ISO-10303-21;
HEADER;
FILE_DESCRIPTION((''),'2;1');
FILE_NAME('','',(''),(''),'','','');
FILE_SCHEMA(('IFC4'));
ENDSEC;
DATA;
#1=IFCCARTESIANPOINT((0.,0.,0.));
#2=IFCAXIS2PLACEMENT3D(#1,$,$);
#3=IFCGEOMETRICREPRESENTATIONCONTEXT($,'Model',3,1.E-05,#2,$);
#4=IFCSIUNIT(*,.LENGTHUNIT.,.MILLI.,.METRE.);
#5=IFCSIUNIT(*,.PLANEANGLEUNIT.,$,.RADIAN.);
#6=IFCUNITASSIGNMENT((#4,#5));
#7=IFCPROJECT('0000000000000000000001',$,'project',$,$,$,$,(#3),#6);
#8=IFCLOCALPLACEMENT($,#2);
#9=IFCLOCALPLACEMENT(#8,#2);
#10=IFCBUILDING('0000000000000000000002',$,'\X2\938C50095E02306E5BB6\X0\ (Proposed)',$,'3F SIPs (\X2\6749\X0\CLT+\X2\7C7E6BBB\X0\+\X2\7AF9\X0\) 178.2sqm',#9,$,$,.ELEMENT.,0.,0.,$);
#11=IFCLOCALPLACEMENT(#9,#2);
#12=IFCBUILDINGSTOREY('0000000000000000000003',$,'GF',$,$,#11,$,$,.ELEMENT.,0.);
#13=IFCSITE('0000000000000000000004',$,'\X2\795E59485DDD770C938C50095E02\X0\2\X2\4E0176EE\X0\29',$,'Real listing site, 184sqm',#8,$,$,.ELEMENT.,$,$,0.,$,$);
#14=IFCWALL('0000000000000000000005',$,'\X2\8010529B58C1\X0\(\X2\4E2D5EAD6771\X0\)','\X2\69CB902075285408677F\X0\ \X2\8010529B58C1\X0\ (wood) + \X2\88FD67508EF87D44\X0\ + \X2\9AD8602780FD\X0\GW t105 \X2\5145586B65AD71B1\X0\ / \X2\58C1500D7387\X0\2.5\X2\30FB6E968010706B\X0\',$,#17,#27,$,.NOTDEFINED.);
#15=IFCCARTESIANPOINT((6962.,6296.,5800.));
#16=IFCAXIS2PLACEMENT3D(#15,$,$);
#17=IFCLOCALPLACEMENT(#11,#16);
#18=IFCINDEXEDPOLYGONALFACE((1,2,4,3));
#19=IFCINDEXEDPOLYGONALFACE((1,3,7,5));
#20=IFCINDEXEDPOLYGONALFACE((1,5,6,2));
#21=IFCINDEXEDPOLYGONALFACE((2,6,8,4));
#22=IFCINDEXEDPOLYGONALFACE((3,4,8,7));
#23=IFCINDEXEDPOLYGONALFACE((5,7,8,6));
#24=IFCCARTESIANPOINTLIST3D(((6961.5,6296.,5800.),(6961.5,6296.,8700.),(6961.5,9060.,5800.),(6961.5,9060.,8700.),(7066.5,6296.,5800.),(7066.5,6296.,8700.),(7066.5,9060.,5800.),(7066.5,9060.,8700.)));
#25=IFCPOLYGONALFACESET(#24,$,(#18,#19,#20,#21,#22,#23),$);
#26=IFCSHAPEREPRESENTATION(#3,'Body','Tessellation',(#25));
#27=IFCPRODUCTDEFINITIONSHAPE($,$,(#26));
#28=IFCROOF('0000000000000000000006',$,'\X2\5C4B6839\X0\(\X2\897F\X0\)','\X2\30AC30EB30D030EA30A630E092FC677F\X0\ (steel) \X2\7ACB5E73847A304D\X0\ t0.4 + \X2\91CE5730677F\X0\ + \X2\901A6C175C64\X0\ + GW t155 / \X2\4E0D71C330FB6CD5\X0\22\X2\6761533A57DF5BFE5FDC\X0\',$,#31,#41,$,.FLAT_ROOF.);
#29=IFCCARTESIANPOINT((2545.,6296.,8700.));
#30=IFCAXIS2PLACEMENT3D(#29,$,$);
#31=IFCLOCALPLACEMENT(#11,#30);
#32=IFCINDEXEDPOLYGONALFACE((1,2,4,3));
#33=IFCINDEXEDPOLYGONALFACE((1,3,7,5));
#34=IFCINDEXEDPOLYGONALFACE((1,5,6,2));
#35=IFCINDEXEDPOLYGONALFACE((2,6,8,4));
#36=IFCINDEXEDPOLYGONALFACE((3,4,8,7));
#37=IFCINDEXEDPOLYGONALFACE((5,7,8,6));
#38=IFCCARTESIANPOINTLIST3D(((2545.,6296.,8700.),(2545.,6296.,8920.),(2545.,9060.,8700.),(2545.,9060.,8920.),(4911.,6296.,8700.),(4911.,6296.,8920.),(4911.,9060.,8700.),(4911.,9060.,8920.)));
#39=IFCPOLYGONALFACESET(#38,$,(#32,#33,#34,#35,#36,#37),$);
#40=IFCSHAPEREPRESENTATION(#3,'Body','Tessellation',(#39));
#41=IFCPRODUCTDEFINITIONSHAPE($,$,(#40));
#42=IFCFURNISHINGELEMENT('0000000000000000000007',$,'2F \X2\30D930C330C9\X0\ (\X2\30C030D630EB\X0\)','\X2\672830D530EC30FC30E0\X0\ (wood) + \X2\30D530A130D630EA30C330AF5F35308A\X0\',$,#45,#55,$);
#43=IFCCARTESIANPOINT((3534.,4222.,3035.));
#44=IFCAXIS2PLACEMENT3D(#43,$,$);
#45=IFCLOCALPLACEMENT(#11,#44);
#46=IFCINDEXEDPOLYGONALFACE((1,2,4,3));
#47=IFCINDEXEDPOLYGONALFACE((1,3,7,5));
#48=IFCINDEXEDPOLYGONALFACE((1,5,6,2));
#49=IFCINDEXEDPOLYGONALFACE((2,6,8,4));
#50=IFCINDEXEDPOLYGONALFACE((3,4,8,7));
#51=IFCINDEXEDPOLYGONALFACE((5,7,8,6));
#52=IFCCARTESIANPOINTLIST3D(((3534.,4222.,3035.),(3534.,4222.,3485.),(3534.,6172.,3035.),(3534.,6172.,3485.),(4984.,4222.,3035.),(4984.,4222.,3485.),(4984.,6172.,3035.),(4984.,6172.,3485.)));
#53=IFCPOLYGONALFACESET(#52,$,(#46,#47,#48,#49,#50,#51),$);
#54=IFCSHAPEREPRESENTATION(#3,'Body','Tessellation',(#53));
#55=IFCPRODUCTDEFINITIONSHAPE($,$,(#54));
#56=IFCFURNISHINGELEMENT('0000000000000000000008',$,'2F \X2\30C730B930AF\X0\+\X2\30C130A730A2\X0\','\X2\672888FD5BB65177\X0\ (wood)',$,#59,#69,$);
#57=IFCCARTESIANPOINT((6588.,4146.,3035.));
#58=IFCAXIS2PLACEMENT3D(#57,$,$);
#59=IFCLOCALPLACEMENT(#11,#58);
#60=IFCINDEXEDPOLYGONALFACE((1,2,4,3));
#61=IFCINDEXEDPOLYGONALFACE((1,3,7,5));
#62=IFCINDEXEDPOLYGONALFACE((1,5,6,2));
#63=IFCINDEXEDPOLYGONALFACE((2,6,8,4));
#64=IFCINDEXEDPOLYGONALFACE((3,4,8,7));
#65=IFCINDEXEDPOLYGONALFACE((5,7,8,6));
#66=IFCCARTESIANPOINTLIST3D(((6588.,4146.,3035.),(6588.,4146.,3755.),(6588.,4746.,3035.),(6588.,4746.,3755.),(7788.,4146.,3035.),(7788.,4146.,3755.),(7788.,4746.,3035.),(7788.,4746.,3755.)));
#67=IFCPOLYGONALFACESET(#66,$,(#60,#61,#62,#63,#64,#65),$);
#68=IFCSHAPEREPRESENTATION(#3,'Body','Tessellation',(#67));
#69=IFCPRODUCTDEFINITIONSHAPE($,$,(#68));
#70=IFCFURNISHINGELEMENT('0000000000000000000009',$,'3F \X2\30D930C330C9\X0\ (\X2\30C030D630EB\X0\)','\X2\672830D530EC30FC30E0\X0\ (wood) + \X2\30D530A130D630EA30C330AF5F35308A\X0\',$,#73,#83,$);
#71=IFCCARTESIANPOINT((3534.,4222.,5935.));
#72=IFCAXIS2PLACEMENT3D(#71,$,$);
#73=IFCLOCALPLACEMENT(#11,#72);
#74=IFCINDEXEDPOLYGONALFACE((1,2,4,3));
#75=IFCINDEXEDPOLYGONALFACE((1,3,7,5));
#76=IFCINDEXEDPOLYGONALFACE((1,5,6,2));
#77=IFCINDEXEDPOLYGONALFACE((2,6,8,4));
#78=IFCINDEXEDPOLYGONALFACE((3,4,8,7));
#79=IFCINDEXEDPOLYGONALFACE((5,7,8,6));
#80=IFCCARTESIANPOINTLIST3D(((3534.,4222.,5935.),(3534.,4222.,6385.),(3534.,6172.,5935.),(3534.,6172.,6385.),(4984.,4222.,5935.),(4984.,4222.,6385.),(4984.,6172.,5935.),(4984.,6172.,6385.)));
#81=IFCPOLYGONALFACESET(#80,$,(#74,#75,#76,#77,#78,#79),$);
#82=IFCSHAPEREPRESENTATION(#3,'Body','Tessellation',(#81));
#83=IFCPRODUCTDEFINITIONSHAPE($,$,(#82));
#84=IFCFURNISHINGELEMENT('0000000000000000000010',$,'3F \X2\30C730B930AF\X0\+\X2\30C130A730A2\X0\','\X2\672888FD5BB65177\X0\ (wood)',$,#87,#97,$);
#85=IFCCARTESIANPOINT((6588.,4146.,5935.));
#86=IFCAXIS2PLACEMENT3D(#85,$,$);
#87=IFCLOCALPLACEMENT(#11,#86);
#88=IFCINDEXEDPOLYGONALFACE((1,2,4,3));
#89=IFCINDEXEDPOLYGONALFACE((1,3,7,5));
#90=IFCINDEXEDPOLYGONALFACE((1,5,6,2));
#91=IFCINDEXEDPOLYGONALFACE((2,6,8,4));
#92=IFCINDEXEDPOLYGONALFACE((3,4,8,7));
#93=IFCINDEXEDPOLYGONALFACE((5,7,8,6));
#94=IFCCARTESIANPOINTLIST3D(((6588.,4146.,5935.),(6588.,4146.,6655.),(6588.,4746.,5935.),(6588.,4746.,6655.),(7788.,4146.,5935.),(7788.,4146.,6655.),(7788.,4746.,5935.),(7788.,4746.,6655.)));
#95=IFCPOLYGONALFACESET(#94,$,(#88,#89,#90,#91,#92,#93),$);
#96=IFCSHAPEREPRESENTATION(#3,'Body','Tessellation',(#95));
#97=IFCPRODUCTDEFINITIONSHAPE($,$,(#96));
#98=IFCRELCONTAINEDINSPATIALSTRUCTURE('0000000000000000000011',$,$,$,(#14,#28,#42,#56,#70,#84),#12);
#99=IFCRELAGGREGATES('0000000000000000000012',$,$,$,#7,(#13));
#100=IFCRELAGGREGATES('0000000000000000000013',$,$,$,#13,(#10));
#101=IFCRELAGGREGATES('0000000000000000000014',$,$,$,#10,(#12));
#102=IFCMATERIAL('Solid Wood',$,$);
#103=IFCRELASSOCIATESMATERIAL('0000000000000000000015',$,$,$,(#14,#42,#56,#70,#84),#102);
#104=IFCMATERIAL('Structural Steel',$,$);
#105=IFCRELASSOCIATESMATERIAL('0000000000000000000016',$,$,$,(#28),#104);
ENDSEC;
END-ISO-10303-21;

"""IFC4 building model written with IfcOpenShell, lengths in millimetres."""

from ifc_helpers import new_model, si_unit, frame, frame_2d, origin, place, context, project, spatial, rectangle, extrude, material, element, save


model = new_model("IFC4")

# Units and contexts
model_context = context("Model", 3, precision=1e-05, world=origin())
ifc_project = project(units=[si_unit("LENGTHUNIT", "METRE", prefix="MILLI"), si_unit("PLANEANGLEUNIT", "RADIAN")], contexts=[model_context])

# Site, building, storey
site_placement = place(None, origin())
site = spatial("IfcSite", under=ifc_project, at=site_placement, Name="神奈川県鎌倉市2丁目29", ObjectType="Real listing site, 184sqm", CompositionType="ELEMENT", RefElevation=0.0)
building_placement = place(site_placement, origin())
building = spatial("IfcBuilding", under=site, at=building_placement, Name="鎌倉市の家 (Proposed)", ObjectType="3F SIPs (杉CLT+籾殻+竹) 178.2sqm", CompositionType="ELEMENT", ElevationOfRefHeight=0.0, ElevationOfTerrain=0.0)
storey_placement = place(building_placement, origin())
storey = spatial("IfcBuildingStorey", under=building, at=storey_placement, Name="GF", CompositionType="ELEMENT", Elevation=0.0)

# Shared definitions
ifc_material_1 = material(Name="Solid Wood")

# Wall
wall_1_placement = place(storey_placement, frame((6962.0, 6296.0, 5800.0)))
element("IfcWall", 1, at=wall_1_placement, inside=storey, material=ifc_material_1, Name="耐力壁(中庭東)", Description="構造用合板 耐力壁 (wood) + 製材軸組 + 高性能GW t105 充填断熱 / 壁倍率2.5・準耐火", PredefinedType="NOTDEFINED", context=model_context, shape_type="SweptSolid", body=[
    extrude(rectangle(XDim=105.0, YDim=2764.0, at=frame_2d((52.0, 1382.0))), frame((6962.0, 6296.0, 5800.0)), (0.0, 0.0, 1.0), 2900.0),
])

# Roof
ifc_material_2 = material(Name="Structural Steel")
roof_1_placement = place(storey_placement, frame((2545.0, 6296.0, 8700.0)))
element("IfcRoof", 2, at=roof_1_placement, inside=storey, material=ifc_material_2, Name="屋根(西)", Description="ガルバリウム鋼板 (steel) 立平葺き t0.4 + 野地板 + 通気層 + GW t155 / 不燃・法22条区域対応", PredefinedType="FLAT_ROOF", context=model_context, shape_type="SweptSolid", body=[
    extrude(rectangle(XDim=2366.0, YDim=2764.0, at=frame_2d((1183.0, 1382.0))), frame((2545.0, 6296.0, 8700.0)), (0.0, 0.0, 1.0), 220.0),
])

# Furnishing elements
furnishing_1_placement = place(storey_placement, frame((3534.0, 4222.0, 3035.0)))
element("IfcFurnishingElement", 3, at=furnishing_1_placement, inside=storey, material=ifc_material_1, Name="2F ベッド (ダブル)", Description="木フレーム (wood) + ファブリック張り", context=model_context, shape_type="SweptSolid", body=[
    extrude(rectangle(XDim=1450.0, YDim=1950.0, at=frame_2d((725.0, 975.0))), frame((3534.0, 4222.0, 3035.0)), (0.0, 0.0, 1.0), 450.0),
])
furnishing_2_placement = place(storey_placement, frame((6588.0, 4146.0, 3035.0)))
element("IfcFurnishingElement", 4, at=furnishing_2_placement, inside=storey, material=ifc_material_1, Name="2F デスク+チェア", Description="木製家具 (wood)", context=model_context, shape_type="SweptSolid", body=[
    extrude(rectangle(XDim=1200.0, YDim=600.0, at=frame_2d((600.0, 300.0))), frame((6588.0, 4146.0, 3035.0)), (0.0, 0.0, 1.0), 720.0),
])
furnishing_3_placement = place(storey_placement, frame((3534.0, 4222.0, 5935.0)))
element("IfcFurnishingElement", 5, at=furnishing_3_placement, inside=storey, material=ifc_material_1, Name="3F ベッド (ダブル)", Description="木フレーム (wood) + ファブリック張り", context=model_context, shape_type="SweptSolid", body=[
    extrude(rectangle(XDim=1450.0, YDim=1950.0, at=frame_2d((725.0, 975.0))), frame((3534.0, 4222.0, 5935.0)), (0.0, 0.0, 1.0), 450.0),
])
furnishing_4_placement = place(storey_placement, frame((6588.0, 4146.0, 5935.0)))
element("IfcFurnishingElement", 6, at=furnishing_4_placement, inside=storey, material=ifc_material_1, Name="3F デスク+チェア", Description="木製家具 (wood)", context=model_context, shape_type="SweptSolid", body=[
    extrude(rectangle(XDim=1200.0, YDim=600.0, at=frame_2d((600.0, 300.0))), frame((6588.0, 4146.0, 5935.0)), (0.0, 0.0, 1.0), 720.0),
])

save(model, "model.ifc")
